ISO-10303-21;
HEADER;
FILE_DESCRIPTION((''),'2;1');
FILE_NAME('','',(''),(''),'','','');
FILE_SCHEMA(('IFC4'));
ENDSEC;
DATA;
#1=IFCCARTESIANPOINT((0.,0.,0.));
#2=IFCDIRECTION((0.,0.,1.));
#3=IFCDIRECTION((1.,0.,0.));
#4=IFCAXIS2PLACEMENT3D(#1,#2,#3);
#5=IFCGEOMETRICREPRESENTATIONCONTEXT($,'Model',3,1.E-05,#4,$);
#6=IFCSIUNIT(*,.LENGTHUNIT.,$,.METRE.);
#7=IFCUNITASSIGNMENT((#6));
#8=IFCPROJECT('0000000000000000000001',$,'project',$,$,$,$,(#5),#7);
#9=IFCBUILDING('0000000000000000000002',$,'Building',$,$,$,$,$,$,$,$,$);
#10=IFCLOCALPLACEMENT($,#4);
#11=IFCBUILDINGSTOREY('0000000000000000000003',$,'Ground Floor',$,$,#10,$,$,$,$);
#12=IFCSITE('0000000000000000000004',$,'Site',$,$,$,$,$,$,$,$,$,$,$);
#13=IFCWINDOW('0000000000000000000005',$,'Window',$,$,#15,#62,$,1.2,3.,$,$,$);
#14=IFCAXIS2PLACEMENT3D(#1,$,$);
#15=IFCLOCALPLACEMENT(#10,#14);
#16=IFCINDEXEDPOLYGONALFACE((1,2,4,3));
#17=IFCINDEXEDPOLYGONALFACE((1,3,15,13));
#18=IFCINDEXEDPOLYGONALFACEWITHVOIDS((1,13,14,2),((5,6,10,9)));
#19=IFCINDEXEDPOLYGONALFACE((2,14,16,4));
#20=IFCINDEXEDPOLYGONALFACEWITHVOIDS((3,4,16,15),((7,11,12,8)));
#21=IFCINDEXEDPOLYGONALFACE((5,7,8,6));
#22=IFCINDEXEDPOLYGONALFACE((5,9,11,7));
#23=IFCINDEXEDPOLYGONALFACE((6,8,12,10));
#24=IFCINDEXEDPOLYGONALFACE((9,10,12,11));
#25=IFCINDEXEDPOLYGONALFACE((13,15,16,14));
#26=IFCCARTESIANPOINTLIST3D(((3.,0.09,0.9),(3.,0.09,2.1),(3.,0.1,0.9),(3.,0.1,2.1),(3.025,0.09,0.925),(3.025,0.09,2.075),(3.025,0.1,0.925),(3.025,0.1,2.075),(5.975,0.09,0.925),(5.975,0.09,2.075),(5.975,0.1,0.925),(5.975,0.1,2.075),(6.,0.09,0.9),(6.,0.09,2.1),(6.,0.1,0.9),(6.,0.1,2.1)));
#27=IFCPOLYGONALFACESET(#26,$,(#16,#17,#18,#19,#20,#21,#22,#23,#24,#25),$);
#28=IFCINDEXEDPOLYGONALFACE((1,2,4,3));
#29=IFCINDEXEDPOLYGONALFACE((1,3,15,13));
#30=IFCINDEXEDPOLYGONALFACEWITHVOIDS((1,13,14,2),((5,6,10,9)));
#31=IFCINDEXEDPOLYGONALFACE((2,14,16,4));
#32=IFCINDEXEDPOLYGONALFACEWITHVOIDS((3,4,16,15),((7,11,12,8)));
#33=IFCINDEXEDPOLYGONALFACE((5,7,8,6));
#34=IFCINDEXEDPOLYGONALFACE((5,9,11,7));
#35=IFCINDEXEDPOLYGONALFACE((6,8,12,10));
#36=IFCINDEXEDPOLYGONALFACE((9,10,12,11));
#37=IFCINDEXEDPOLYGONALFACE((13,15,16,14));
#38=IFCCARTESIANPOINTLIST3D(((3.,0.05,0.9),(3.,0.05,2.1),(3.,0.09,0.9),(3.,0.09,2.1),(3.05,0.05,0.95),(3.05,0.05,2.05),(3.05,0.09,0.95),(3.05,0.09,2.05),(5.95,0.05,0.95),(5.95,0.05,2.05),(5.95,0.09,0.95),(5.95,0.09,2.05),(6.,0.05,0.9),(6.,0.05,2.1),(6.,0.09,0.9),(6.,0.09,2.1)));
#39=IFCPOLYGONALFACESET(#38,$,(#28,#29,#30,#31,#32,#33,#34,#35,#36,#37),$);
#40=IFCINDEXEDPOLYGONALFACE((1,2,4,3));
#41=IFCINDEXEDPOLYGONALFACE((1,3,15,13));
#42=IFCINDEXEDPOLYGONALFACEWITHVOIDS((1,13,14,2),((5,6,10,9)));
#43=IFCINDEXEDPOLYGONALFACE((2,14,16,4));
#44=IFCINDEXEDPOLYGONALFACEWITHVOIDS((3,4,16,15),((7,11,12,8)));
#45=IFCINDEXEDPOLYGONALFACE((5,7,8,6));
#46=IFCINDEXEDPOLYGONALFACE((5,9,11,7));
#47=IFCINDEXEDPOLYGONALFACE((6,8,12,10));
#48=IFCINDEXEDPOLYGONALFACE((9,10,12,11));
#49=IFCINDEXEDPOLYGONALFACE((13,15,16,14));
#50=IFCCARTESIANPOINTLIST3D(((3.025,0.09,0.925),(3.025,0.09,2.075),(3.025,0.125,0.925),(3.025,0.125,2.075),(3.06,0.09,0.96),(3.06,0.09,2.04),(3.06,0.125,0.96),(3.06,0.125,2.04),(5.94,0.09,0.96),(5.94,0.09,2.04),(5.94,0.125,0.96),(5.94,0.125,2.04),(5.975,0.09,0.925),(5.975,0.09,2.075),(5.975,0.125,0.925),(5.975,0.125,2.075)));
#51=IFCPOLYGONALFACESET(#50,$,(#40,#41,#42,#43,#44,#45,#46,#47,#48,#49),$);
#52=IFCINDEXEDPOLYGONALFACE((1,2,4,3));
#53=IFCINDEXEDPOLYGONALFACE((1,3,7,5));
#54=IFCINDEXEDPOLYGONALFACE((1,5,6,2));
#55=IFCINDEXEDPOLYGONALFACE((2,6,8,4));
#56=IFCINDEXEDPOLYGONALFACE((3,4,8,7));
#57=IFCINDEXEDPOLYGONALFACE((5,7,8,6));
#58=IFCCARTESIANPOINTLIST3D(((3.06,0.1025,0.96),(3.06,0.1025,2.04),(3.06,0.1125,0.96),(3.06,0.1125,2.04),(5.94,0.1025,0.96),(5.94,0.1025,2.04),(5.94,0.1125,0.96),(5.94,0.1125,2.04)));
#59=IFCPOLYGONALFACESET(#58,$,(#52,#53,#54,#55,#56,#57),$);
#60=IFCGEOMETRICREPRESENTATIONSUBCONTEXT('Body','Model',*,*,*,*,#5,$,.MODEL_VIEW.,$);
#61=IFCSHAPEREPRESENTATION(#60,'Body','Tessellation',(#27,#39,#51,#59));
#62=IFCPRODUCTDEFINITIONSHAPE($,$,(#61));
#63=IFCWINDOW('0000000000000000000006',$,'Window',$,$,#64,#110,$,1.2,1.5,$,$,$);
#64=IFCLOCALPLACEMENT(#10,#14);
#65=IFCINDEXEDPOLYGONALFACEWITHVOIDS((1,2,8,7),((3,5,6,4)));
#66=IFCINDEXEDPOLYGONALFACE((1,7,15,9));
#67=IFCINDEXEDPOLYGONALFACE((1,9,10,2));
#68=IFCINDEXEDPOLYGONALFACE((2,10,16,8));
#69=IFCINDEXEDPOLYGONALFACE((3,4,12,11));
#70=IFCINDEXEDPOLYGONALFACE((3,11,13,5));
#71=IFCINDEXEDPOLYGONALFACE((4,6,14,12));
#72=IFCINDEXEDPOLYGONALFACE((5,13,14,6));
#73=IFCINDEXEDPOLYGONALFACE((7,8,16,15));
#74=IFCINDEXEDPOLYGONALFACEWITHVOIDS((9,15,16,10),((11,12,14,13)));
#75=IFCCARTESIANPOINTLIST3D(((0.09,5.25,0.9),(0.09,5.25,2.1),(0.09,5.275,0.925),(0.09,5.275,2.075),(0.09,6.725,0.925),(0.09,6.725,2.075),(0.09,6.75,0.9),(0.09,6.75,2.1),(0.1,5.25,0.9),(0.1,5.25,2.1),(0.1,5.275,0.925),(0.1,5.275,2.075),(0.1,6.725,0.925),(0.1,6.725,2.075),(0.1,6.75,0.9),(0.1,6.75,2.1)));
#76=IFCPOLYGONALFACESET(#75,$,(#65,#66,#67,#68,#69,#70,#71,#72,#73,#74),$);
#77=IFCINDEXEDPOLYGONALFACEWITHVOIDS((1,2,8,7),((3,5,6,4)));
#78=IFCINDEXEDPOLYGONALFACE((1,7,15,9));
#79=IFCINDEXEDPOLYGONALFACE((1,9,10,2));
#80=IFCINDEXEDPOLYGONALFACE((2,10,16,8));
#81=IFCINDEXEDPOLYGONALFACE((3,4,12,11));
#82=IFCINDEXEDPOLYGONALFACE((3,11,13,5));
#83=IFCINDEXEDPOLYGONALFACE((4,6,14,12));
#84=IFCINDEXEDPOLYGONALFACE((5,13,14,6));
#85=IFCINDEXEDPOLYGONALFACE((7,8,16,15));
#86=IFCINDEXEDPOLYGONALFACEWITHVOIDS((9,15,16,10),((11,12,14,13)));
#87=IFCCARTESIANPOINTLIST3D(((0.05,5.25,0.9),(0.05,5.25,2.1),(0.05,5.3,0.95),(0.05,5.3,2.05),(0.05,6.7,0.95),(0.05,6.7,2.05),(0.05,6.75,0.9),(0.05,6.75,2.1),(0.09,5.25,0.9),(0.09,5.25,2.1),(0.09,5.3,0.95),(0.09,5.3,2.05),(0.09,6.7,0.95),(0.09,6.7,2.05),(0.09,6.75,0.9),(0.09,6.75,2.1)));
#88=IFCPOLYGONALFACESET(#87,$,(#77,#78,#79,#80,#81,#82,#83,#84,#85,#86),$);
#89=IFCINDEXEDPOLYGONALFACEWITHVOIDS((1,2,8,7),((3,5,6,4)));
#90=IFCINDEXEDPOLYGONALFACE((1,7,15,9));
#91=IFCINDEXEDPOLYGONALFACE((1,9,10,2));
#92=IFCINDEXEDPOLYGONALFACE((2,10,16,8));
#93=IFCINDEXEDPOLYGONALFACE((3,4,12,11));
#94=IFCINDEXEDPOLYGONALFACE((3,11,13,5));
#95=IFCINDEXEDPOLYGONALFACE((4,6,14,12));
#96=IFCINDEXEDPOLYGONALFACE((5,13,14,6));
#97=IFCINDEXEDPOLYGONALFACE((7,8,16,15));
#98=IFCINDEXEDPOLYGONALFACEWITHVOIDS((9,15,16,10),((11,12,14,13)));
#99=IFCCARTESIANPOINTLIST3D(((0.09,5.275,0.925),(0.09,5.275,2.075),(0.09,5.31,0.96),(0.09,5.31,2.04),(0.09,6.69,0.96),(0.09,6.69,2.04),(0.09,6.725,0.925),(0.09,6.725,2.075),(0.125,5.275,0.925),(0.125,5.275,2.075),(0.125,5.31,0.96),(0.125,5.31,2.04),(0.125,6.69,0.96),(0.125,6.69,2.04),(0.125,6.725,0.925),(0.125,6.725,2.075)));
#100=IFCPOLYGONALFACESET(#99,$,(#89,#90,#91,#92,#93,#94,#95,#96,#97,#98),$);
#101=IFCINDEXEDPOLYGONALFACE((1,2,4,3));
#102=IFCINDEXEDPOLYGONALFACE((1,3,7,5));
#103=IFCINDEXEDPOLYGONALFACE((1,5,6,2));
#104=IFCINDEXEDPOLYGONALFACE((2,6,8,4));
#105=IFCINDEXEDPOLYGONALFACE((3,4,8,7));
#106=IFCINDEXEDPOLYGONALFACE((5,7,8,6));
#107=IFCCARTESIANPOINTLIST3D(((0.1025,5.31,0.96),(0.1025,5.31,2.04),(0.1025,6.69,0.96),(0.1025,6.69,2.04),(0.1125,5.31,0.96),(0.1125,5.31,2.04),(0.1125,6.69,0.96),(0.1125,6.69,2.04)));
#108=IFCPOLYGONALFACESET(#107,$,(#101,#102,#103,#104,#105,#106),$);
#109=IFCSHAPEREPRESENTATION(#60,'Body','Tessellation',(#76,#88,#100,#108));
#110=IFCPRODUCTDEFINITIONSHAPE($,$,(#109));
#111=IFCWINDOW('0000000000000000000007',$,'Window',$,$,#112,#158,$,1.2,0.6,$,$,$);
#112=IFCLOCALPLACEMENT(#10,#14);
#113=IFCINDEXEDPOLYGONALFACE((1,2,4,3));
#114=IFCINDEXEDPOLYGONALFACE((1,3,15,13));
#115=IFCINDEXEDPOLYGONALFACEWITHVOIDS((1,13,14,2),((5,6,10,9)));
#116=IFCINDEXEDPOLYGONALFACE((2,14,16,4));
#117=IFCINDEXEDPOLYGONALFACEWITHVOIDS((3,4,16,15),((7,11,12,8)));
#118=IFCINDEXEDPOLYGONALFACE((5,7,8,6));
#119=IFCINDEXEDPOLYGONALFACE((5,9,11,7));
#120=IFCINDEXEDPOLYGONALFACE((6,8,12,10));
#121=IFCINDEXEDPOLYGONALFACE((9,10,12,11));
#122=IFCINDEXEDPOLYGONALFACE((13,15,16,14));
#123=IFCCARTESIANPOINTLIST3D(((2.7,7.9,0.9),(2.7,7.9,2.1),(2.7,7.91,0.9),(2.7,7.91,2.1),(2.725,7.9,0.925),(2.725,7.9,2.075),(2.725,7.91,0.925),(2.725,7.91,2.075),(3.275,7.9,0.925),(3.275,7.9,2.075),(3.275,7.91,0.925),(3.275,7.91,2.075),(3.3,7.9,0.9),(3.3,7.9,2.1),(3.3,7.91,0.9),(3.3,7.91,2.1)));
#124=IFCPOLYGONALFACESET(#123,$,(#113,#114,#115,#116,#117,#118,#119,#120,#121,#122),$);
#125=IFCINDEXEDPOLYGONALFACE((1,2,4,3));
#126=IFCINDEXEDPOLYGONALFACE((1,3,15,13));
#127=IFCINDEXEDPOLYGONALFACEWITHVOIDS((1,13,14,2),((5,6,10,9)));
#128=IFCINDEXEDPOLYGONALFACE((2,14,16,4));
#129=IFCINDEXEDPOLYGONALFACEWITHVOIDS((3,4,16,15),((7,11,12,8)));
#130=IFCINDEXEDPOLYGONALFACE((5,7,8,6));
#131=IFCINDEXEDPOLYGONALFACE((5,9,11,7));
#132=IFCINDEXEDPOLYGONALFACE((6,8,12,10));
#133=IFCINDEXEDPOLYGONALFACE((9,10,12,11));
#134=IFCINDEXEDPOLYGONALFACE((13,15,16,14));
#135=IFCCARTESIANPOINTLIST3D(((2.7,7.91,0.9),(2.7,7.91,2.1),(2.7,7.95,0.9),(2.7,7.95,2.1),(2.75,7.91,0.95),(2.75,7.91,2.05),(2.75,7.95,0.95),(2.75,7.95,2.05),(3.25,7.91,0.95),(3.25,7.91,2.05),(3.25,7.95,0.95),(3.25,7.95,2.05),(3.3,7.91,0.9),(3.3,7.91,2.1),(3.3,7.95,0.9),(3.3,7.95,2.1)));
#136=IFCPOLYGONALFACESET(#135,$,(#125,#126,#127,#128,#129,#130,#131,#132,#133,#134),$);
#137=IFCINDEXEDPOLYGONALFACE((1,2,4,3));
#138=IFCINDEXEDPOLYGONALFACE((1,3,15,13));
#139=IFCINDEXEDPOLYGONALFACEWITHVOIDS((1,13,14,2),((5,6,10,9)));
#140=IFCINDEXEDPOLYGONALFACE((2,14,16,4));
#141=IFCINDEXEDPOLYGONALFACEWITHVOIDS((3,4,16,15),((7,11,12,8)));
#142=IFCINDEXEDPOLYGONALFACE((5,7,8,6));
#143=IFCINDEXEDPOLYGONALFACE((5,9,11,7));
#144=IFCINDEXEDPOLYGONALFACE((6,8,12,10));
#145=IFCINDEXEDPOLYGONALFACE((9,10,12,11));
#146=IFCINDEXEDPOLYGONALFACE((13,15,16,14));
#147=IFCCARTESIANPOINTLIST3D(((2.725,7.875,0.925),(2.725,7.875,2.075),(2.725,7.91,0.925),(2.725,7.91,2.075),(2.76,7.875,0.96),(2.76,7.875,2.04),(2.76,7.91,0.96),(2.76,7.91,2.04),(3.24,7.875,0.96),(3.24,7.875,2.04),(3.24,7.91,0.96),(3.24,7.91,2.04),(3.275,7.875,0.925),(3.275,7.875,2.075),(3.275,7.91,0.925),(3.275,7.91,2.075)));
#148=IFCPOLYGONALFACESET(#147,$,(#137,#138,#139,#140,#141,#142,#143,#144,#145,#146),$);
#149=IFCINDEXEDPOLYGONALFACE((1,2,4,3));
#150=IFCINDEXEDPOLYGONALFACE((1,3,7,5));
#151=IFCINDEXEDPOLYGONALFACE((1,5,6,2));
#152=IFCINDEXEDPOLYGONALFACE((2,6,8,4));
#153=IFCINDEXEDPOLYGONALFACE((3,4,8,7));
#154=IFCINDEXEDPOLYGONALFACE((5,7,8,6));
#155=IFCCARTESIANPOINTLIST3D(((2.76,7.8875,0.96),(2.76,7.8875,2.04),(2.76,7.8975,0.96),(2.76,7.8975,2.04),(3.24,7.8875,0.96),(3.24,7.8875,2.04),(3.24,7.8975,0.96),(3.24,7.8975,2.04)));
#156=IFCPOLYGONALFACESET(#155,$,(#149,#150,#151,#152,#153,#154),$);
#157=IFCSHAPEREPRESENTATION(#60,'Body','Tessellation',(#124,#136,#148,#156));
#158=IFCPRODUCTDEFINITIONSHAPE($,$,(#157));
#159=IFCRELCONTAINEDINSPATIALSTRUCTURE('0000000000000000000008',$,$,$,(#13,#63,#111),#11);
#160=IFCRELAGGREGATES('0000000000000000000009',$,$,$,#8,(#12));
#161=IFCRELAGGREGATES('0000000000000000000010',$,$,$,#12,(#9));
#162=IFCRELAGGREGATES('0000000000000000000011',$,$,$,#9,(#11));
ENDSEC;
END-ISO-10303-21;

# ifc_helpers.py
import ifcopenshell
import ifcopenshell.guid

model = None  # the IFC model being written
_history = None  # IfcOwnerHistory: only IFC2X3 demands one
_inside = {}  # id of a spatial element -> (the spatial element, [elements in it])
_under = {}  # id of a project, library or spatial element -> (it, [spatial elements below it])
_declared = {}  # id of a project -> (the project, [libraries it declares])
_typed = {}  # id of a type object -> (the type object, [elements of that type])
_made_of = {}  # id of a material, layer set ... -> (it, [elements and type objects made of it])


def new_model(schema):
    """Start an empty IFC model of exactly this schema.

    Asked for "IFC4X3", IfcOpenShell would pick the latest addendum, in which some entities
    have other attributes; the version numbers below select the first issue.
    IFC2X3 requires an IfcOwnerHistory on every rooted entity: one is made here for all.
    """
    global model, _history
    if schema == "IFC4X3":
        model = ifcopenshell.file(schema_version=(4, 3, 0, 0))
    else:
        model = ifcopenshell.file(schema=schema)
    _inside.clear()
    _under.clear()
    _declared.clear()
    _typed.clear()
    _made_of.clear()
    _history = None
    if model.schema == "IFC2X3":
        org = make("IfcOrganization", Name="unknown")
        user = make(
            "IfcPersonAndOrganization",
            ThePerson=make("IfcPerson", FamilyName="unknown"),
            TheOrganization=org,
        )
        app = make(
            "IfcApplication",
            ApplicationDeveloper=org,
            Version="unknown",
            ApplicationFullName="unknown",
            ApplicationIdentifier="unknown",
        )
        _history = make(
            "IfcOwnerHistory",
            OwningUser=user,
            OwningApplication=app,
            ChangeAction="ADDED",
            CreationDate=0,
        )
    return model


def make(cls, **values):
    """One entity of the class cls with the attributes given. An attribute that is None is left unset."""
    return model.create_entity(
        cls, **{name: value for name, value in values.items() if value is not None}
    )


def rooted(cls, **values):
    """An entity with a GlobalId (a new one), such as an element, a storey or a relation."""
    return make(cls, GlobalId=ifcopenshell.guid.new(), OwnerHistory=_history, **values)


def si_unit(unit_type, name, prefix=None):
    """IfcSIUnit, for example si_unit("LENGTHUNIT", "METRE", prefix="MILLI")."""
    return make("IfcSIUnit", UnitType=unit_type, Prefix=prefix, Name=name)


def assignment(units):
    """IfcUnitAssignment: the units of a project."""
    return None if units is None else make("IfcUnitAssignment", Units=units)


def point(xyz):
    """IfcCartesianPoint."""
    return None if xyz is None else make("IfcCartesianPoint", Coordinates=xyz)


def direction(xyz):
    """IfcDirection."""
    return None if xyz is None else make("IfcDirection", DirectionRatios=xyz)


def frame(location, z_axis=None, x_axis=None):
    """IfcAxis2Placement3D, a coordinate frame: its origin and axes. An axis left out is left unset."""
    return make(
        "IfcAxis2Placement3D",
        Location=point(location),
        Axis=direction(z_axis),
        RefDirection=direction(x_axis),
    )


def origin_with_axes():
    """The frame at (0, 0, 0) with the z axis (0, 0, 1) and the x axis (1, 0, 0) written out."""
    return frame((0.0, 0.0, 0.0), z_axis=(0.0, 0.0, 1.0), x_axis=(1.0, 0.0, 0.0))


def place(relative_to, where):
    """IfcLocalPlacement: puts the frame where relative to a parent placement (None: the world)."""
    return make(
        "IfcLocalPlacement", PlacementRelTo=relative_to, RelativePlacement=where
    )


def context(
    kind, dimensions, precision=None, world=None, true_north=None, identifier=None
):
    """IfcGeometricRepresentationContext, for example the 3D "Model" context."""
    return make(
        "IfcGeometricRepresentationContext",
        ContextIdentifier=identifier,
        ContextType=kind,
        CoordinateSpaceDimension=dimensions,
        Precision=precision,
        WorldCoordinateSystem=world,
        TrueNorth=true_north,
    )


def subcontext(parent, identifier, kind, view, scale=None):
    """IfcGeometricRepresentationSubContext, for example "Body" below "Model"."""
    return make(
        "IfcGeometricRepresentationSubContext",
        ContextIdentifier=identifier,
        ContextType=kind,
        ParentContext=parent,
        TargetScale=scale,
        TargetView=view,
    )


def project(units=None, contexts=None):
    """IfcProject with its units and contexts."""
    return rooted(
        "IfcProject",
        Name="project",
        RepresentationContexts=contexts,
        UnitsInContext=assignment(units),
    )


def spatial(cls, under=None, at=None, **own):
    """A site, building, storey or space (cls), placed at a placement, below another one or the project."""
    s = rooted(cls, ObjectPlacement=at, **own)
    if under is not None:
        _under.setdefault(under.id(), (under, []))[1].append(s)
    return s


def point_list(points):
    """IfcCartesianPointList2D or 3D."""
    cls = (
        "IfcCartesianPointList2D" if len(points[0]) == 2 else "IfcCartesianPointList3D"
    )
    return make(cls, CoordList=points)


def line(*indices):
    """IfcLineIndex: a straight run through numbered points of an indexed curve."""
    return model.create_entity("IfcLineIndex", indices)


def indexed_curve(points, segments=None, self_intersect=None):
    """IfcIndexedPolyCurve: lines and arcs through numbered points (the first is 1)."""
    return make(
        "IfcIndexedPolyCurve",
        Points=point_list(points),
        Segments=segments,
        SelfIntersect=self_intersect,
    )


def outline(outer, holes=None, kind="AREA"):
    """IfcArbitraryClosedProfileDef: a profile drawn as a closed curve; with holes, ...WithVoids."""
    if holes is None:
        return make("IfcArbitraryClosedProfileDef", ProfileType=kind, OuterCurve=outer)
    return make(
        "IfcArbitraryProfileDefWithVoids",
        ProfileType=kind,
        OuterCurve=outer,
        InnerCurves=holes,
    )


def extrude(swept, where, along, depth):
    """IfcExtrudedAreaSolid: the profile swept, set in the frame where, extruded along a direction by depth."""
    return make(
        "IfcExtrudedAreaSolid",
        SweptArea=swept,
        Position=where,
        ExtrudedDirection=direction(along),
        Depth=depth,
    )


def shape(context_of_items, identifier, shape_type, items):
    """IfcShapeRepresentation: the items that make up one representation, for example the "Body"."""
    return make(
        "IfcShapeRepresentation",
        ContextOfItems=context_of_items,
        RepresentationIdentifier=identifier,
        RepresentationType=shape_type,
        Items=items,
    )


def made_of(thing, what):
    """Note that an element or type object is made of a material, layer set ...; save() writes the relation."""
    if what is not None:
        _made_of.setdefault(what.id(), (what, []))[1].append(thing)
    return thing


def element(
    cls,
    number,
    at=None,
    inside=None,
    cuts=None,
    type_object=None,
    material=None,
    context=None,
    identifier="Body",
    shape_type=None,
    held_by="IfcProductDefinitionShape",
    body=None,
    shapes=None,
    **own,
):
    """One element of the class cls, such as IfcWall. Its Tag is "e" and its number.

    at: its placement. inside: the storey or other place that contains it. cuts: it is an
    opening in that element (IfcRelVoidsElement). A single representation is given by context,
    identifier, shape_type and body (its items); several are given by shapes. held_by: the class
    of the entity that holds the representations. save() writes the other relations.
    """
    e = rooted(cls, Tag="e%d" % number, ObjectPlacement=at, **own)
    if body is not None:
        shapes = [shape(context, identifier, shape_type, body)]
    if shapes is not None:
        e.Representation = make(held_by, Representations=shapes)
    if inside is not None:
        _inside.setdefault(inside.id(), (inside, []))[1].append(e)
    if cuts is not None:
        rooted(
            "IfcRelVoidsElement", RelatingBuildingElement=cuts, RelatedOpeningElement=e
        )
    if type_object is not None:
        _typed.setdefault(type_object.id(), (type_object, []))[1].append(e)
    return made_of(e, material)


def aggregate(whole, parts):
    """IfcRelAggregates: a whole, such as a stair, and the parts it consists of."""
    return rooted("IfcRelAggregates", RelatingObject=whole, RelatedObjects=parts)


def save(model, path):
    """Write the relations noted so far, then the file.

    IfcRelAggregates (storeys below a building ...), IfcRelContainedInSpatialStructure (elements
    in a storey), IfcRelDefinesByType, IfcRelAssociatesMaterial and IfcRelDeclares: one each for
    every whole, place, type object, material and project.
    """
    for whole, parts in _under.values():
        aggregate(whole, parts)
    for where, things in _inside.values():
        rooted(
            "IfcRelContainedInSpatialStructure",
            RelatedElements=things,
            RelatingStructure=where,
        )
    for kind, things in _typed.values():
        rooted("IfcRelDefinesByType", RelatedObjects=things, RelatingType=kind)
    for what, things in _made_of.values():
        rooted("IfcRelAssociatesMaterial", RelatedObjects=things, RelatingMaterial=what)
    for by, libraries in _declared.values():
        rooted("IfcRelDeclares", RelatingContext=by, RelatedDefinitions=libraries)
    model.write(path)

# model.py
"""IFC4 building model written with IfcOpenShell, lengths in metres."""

from ifc_helpers import new_model, si_unit, frame, origin_with_axes, place, context, subcontext, project, spatial, line, indexed_curve, outline, extrude, element, save


model = new_model("IFC4")

# Units and contexts
model_context = context("Model", 3, precision=1e-05, world=origin_with_axes())
body_context = subcontext(model_context, "Body", "Model", "MODEL_VIEW")
ifc_project = project(units=[si_unit("LENGTHUNIT", "METRE")], contexts=[model_context])

# Site, building, storey
site = spatial("IfcSite", under=ifc_project, Name="Site")
building = spatial("IfcBuilding", under=site, Name="Building")
storey_placement = place(None, origin_with_axes())
storey = spatial("IfcBuildingStorey", under=building, at=storey_placement, Name="Ground Floor")

# Windows
window_1_placement = place(storey_placement, frame((3.0, 0.0, 0.9), z_axis=(0.0, 0.0, 1.0), x_axis=(1.0, 0.0, 0.0)))
element("IfcWindow", 1, at=window_1_placement, inside=storey, Name="Window", OverallHeight=1.2, OverallWidth=3.0, context=body_context, shape_type="SweptSolid", body=[
    extrude(outline(indexed_curve([(0.0, 0.0), (3.0, 0.0), (3.0, 1.2), (0.0, 1.2)], segments=[line(1, 2, 3, 4, 1)]), holes=[indexed_curve([(0.025, 0.025), (2.975, 0.025), (2.975, 1.175), (0.025, 1.175)], segments=[line(1, 2, 3, 4, 1)])]), frame((0.0, 0.09, 0.0), z_axis=(0.0, -1.0, 0.0), x_axis=(1.0, 0.0, 0.0)), (0.0, 0.0, -1.0), 0.01),
    extrude(outline(indexed_curve([(0.0, 0.0), (3.0, 0.0), (3.0, 1.2), (0.0, 1.2)], segments=[line(1, 2, 3, 4, 1)]), holes=[indexed_curve([(0.05, 0.05), (2.95, 0.05), (2.95, 1.15), (0.05, 1.15)], segments=[line(1, 2, 3, 4, 1)])]), frame((0.0, 0.05, 0.0), z_axis=(0.0, -1.0, 0.0), x_axis=(1.0, 0.0, 0.0)), (0.0, 0.0, -1.0), 0.04),
    extrude(outline(indexed_curve([(0.0, 0.0), (2.95, 0.0), (2.95, 1.15), (0.0, 1.15)], segments=[line(1, 2, 3, 4, 1)]), holes=[indexed_curve([(0.035, 0.035), (2.915, 0.035), (2.915, 1.115), (0.035, 1.115)], segments=[line(1, 2, 3, 4, 1)])]), frame((0.025, 0.09, 0.025), z_axis=(0.0, -1.0, 0.0), x_axis=(1.0, 0.0, 0.0)), (0.0, 0.0, -1.0), 0.035),
    extrude(outline(indexed_curve([(0.035, 0.035), (2.915, 0.035), (2.915, 1.115), (0.035, 1.115)], segments=[line(1, 2, 3, 4, 1)])), frame((0.025, 0.1025, 0.025), z_axis=(0.0, -1.0, 0.0), x_axis=(1.0, 0.0, 0.0)), (0.0, 0.0, -1.0), 0.01),
])
window_2_placement = place(storey_placement, frame((0.0, 6.75, 0.9), z_axis=(0.0, 0.0, 1.0), x_axis=(0.0, -1.0, 0.0)))
element("IfcWindow", 2, at=window_2_placement, inside=storey, Name="Window", OverallHeight=1.2, OverallWidth=1.5, context=body_context, shape_type="SweptSolid", body=[
    extrude(outline(indexed_curve([(0.0, 0.0), (1.5, 0.0), (1.5, 1.2), (0.0, 1.2)], segments=[line(1, 2, 3, 4, 1)]), holes=[indexed_curve([(0.025, 0.025), (1.475, 0.025), (1.475, 1.175), (0.025, 1.175)], segments=[line(1, 2, 3, 4, 1)])]), frame((0.0, 0.09, 0.0), z_axis=(0.0, -1.0, 0.0), x_axis=(1.0, 0.0, 0.0)), (0.0, 0.0, -1.0), 0.01),
    extrude(outline(indexed_curve([(0.0, 0.0), (1.5, 0.0), (1.5, 1.2), (0.0, 1.2)], segments=[line(1, 2, 3, 4, 1)]), holes=[indexed_curve([(0.05, 0.05), (1.45, 0.05), (1.45, 1.15), (0.05, 1.15)], segments=[line(1, 2, 3, 4, 1)])]), frame((0.0, 0.05, 0.0), z_axis=(0.0, -1.0, 0.0), x_axis=(1.0, 0.0, 0.0)), (0.0, 0.0, -1.0), 0.04),
    extrude(outline(indexed_curve([(0.0, 0.0), (1.45, 0.0), (1.45, 1.15), (0.0, 1.15)], segments=[line(1, 2, 3, 4, 1)]), holes=[indexed_curve([(0.035, 0.035), (1.415, 0.035), (1.415, 1.115), (0.035, 1.115)], segments=[line(1, 2, 3, 4, 1)])]), frame((0.025, 0.09, 0.025), z_axis=(0.0, -1.0, 0.0), x_axis=(1.0, 0.0, 0.0)), (0.0, 0.0, -1.0), 0.035),
    extrude(outline(indexed_curve([(0.035, 0.035), (1.415, 0.035), (1.415, 1.115), (0.035, 1.115)], segments=[line(1, 2, 3, 4, 1)])), frame((0.025, 0.1025, 0.025), z_axis=(0.0, -1.0, 0.0), x_axis=(1.0, 0.0, 0.0)), (0.0, 0.0, -1.0), 0.01),
])
window_3_placement = place(storey_placement, frame((3.3, 8.0, 0.9), z_axis=(0.0, 0.0, 1.0), x_axis=(-1.0, 0.0, 0.0)))
element("IfcWindow", 3, at=window_3_placement, inside=storey, Name="Window", OverallHeight=1.2, OverallWidth=0.6, context=body_context, shape_type="SweptSolid", body=[
    extrude(outline(indexed_curve([(0.0, 0.0), (0.6, 0.0), (0.6, 1.2), (0.0, 1.2)], segments=[line(1, 2, 3, 4, 1)]), holes=[indexed_curve([(0.025, 0.025), (0.575, 0.025), (0.575, 1.175), (0.025, 1.175)], segments=[line(1, 2, 3, 4, 1)])]), frame((0.0, 0.09, 0.0), z_axis=(0.0, -1.0, 0.0), x_axis=(1.0, 0.0, 0.0)), (0.0, 0.0, -1.0), 0.01),
    extrude(outline(indexed_curve([(0.0, 0.0), (0.6, 0.0), (0.6, 1.2), (0.0, 1.2)], segments=[line(1, 2, 3, 4, 1)]), holes=[indexed_curve([(0.05, 0.05), (0.55, 0.05), (0.55, 1.15), (0.05, 1.15)], segments=[line(1, 2, 3, 4, 1)])]), frame((0.0, 0.05, 0.0), z_axis=(0.0, -1.0, 0.0), x_axis=(1.0, 0.0, 0.0)), (0.0, 0.0, -1.0), 0.04),
    extrude(outline(indexed_curve([(0.0, 0.0), (0.55, 0.0), (0.55, 1.15), (0.0, 1.15)], segments=[line(1, 2, 3, 4, 1)]), holes=[indexed_curve([(0.035, 0.035), (0.515, 0.035), (0.515, 1.115), (0.035, 1.115)], segments=[line(1, 2, 3, 4, 1)])]), frame((0.025, 0.09, 0.025), z_axis=(0.0, -1.0, 0.0), x_axis=(1.0, 0.0, 0.0)), (0.0, 0.0, -1.0), 0.035),
    extrude(outline(indexed_curve([(0.035, 0.035), (0.515, 0.035), (0.515, 1.115), (0.035, 1.115)], segments=[line(1, 2, 3, 4, 1)])), frame((0.025, 0.1025, 0.025), z_axis=(0.0, -1.0, 0.0), x_axis=(1.0, 0.0, 0.0)), (0.0, 0.0, -1.0), 0.01),
])

save(model, "model.ifc")
